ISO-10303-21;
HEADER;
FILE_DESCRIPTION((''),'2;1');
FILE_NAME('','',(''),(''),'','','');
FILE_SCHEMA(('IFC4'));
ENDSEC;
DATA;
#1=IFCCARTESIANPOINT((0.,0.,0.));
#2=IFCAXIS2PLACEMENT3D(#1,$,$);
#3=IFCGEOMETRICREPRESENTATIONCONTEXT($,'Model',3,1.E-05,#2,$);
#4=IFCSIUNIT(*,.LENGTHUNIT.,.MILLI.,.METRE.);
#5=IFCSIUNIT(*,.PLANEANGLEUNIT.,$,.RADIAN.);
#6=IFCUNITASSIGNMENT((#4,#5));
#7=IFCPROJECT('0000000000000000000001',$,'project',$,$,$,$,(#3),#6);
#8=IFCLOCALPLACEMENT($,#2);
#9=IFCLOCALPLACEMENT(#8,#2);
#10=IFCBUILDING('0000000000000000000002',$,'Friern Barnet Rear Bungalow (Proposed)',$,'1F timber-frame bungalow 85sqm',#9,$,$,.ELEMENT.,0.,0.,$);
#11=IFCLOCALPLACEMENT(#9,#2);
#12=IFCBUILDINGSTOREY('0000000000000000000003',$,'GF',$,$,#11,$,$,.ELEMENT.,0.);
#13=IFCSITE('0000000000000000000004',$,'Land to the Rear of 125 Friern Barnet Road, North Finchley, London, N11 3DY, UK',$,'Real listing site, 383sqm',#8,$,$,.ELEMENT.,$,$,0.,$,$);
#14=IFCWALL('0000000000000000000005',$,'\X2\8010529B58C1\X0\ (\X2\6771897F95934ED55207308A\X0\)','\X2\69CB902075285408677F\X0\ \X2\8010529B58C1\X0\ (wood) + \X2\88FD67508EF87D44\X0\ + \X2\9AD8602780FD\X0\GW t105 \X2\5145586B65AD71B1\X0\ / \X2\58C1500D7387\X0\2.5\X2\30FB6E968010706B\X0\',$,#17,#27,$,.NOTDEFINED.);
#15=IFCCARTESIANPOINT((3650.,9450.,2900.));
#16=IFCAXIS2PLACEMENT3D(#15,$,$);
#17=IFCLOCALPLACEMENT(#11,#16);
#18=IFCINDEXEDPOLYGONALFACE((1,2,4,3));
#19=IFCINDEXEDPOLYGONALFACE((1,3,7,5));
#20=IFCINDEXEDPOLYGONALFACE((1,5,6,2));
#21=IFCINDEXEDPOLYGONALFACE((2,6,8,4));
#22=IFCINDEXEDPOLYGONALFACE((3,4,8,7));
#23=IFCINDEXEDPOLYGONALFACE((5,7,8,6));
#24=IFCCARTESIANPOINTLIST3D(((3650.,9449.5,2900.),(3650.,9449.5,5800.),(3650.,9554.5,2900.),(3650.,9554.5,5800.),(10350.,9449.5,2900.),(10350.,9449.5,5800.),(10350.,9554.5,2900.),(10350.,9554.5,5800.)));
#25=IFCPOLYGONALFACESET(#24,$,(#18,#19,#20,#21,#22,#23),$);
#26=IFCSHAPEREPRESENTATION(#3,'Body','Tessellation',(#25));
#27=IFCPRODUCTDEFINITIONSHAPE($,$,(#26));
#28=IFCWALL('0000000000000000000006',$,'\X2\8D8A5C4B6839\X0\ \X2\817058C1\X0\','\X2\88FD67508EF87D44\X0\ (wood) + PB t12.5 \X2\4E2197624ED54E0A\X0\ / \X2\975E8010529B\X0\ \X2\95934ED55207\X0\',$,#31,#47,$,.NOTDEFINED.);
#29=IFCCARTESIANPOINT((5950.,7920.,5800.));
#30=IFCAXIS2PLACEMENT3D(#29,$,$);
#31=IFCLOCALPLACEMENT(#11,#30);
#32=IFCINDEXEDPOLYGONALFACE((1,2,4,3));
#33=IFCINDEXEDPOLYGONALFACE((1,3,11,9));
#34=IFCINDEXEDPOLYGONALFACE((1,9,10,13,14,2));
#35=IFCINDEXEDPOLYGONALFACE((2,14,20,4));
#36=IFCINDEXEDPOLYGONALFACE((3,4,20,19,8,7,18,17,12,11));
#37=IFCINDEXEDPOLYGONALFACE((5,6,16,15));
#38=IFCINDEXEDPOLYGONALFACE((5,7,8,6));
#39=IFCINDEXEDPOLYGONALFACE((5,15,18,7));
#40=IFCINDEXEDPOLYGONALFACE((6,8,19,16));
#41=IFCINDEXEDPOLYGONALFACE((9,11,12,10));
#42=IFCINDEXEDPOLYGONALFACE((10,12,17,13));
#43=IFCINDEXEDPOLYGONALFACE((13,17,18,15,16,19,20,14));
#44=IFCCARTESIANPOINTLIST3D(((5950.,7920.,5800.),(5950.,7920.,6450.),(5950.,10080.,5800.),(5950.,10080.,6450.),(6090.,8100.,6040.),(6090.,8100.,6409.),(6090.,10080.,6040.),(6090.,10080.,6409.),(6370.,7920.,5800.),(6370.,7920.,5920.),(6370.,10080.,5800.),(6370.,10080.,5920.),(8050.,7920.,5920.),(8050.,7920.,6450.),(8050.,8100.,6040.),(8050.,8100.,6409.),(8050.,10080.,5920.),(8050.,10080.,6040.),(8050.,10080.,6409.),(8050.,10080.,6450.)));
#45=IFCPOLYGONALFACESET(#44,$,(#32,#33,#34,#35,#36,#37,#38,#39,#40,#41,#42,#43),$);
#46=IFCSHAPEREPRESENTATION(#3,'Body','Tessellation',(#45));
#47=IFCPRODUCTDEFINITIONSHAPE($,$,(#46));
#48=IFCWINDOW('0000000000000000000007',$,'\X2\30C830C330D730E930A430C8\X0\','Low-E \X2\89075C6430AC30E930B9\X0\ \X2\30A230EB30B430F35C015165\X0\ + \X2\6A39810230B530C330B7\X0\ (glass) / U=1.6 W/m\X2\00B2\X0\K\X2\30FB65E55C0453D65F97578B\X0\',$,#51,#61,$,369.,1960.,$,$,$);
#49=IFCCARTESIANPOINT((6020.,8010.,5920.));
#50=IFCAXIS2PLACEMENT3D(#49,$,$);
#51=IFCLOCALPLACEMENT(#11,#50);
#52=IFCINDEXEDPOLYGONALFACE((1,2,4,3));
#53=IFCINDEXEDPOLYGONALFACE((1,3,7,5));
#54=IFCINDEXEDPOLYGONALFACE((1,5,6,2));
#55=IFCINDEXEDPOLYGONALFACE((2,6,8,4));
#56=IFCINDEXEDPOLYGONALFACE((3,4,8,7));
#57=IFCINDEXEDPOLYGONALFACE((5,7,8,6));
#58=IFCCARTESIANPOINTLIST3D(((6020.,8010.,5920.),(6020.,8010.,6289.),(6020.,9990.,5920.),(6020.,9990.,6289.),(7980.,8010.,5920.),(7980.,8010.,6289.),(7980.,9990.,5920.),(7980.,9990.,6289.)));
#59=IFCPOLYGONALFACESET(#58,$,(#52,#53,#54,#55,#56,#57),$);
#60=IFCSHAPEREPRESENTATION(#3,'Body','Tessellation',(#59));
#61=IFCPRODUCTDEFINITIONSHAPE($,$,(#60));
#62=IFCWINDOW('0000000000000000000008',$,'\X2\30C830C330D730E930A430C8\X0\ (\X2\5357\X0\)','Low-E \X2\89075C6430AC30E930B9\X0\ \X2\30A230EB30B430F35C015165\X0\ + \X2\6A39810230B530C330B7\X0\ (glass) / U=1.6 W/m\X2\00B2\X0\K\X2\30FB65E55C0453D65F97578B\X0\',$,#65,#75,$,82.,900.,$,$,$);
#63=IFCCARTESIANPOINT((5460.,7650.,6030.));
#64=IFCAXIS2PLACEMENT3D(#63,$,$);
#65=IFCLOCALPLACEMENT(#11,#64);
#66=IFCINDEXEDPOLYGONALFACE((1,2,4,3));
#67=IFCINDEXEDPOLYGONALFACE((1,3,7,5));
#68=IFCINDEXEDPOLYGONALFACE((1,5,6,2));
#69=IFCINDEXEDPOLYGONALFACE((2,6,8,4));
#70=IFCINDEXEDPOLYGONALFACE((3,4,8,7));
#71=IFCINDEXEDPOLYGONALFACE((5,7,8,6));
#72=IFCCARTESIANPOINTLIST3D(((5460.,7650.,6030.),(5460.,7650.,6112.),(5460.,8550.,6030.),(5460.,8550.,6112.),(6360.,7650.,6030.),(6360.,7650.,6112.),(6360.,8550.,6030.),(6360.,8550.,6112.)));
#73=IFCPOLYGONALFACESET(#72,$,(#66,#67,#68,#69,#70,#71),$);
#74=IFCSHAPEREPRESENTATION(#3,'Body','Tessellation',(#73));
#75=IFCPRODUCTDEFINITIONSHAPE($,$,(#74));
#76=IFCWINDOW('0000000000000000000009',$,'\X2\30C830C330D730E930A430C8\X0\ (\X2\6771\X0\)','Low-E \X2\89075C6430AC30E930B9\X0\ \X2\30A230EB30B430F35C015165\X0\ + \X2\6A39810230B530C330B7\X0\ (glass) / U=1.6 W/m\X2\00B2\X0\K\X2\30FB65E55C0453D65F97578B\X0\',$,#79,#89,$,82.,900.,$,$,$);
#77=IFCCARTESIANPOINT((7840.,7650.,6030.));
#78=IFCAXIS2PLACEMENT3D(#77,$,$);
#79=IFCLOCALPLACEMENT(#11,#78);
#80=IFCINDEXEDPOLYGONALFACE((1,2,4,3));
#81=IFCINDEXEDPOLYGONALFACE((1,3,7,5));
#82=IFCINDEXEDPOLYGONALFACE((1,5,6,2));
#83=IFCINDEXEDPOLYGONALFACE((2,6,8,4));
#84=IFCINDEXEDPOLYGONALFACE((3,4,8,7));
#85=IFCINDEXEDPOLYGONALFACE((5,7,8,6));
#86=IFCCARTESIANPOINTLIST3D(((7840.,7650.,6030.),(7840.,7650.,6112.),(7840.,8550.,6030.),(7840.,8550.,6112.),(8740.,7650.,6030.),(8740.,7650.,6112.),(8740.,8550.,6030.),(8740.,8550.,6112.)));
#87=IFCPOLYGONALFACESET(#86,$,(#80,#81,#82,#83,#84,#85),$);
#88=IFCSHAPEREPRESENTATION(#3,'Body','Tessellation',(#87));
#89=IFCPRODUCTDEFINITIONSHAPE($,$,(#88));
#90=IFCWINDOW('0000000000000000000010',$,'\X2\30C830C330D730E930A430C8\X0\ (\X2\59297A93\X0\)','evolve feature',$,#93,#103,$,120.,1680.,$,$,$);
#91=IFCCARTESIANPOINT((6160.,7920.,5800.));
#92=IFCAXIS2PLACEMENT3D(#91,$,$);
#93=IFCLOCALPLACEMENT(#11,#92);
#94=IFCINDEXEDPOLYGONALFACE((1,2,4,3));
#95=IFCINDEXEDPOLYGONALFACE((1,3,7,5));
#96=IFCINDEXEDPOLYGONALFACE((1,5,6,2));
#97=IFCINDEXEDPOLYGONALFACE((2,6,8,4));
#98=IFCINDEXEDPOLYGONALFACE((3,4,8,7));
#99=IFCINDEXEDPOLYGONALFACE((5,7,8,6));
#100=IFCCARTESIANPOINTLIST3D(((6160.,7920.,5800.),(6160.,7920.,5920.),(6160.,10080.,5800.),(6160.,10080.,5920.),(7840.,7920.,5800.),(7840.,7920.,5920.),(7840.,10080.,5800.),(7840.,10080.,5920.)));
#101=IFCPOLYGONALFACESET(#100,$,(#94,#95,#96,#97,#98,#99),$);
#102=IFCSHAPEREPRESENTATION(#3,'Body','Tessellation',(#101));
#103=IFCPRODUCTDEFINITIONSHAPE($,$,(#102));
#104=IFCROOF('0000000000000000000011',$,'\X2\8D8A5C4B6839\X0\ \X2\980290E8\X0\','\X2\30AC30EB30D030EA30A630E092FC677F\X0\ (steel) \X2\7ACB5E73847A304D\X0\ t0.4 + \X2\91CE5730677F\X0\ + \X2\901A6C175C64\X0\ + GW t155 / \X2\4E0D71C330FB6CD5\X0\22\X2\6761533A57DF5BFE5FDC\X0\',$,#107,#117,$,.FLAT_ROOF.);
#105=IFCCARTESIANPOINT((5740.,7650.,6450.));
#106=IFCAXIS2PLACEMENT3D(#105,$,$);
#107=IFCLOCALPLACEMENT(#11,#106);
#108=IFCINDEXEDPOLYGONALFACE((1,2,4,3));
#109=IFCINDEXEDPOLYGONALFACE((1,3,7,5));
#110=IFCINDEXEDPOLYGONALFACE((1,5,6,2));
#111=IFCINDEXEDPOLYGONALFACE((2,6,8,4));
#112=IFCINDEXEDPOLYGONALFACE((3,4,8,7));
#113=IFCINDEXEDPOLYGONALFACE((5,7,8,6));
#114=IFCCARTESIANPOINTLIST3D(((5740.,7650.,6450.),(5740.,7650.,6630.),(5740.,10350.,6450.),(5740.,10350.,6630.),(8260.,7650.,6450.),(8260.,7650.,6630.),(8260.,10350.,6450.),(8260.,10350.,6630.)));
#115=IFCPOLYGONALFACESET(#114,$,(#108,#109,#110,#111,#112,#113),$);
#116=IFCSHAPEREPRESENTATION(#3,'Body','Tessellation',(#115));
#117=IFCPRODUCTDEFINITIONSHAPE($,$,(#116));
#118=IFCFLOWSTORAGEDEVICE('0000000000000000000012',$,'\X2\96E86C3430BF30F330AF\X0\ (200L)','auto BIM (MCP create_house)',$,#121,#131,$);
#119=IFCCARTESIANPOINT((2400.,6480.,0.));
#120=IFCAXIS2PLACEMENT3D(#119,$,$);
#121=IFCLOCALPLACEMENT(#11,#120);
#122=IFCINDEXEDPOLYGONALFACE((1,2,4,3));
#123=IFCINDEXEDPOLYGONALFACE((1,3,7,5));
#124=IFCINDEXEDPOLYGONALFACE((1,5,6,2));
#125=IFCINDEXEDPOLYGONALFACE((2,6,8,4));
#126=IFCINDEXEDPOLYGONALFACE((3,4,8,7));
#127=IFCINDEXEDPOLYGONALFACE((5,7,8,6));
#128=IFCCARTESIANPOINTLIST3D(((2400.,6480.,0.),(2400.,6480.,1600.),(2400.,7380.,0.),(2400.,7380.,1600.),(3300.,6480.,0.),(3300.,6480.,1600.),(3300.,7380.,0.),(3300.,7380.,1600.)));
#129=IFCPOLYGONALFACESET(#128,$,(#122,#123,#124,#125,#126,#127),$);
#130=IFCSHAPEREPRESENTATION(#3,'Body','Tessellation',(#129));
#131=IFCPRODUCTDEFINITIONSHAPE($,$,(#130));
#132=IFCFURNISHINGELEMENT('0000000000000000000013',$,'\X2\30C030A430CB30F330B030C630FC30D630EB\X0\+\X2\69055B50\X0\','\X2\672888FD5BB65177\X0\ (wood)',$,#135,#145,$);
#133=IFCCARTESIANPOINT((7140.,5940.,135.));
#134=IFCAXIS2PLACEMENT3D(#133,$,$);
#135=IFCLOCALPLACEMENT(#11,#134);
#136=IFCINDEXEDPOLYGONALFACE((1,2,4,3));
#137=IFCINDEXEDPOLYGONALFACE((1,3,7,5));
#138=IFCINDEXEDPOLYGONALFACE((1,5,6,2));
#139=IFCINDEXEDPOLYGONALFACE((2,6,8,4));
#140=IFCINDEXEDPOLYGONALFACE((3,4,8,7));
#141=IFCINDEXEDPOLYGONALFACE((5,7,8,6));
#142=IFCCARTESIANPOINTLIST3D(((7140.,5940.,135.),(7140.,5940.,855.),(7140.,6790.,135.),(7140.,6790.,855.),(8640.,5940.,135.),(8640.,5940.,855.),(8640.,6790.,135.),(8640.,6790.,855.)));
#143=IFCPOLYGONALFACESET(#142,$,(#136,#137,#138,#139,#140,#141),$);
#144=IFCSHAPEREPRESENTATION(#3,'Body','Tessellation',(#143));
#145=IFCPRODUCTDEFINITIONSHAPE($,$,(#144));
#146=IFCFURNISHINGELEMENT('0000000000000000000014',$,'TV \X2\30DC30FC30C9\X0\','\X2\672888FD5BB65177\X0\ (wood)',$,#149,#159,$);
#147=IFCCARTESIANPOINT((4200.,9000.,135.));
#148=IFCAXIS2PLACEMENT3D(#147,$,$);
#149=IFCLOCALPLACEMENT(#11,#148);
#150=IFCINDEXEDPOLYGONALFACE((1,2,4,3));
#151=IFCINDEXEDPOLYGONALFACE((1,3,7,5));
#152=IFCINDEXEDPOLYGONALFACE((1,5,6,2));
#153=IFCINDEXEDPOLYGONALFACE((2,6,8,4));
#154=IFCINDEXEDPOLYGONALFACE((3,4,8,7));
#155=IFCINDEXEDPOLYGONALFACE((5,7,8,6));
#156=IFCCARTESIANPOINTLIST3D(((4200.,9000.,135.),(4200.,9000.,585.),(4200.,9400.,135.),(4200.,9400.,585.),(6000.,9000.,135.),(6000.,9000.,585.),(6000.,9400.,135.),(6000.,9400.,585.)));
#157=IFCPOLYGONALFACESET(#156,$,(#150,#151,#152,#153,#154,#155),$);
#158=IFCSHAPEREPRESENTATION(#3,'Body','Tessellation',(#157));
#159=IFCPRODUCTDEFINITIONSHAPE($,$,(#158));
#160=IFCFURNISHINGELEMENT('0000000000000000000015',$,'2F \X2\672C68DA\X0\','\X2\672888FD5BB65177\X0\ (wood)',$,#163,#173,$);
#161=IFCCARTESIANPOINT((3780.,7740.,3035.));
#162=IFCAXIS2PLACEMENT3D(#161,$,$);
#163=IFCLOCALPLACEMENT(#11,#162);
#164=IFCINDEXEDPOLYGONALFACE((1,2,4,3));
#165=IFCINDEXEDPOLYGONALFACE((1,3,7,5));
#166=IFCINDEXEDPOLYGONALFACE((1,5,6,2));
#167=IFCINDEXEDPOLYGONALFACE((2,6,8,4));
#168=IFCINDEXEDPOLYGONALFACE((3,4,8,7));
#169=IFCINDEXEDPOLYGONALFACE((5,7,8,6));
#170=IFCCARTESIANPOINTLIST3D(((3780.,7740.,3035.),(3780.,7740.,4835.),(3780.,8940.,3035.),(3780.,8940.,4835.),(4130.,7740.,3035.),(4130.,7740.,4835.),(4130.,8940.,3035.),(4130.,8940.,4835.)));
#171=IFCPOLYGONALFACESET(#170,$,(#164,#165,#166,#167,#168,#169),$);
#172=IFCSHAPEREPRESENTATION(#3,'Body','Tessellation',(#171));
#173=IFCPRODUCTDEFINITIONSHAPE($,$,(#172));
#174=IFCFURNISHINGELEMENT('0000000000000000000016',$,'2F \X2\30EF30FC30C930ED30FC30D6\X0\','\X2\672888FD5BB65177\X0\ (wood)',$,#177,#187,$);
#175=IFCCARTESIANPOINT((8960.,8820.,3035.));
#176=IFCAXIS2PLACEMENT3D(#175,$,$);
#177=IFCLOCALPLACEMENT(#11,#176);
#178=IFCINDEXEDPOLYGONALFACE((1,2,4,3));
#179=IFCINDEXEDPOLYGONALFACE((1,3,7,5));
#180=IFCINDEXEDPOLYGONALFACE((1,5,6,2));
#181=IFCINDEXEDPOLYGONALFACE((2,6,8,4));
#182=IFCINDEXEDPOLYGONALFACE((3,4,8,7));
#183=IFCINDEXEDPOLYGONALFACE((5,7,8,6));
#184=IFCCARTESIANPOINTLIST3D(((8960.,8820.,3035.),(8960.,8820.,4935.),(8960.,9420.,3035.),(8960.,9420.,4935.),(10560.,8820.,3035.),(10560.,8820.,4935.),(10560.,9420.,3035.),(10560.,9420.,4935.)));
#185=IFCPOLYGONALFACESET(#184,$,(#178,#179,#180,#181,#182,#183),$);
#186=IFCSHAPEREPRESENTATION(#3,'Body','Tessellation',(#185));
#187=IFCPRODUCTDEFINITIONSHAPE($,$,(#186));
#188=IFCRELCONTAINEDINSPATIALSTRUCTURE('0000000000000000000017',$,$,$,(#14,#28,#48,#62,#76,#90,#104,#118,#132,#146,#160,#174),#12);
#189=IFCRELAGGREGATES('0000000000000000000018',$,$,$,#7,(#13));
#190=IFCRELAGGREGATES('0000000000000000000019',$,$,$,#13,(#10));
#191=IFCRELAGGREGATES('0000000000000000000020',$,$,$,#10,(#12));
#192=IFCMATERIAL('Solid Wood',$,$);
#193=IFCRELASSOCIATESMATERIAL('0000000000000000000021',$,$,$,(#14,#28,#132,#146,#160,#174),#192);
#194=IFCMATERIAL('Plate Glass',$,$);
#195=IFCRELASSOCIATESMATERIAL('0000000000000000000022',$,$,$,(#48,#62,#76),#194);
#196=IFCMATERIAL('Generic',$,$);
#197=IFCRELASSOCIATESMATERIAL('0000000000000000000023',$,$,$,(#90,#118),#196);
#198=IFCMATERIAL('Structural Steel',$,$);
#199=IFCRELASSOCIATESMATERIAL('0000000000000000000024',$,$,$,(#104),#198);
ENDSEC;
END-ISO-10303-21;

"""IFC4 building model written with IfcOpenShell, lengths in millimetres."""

from ifc_helpers import new_model, si_unit, frame, frame_2d, origin, place, context, project, spatial, rectangle, extrude, material, element, fill, save


model = new_model("IFC4")

# Units and contexts
model_context = context("Model", 3, precision=1e-05, world=origin())
ifc_project = project(units=[si_unit("LENGTHUNIT", "METRE", prefix="MILLI"), si_unit("PLANEANGLEUNIT", "RADIAN")], contexts=[model_context])

# Site, building, storey
site_placement = place(None, origin())
site = spatial("IfcSite", under=ifc_project, at=site_placement, Name="Land to the Rear of 125 Friern Barnet Road, North Finchley, London, N11 3DY, UK", ObjectType="Real listing site, 383sqm", CompositionType="ELEMENT", RefElevation=0.0)
building_placement = place(site_placement, origin())
building = spatial("IfcBuilding", under=site, at=building_placement, Name="Friern Barnet Rear Bungalow (Proposed)", ObjectType="1F timber-frame bungalow 85sqm", CompositionType="ELEMENT", ElevationOfRefHeight=0.0, ElevationOfTerrain=0.0)
storey_placement = place(building_placement, origin())
storey = spatial("IfcBuildingStorey", under=building, at=storey_placement, Name="GF", CompositionType="ELEMENT", Elevation=0.0)

# Wall
ifc_material_1 = material(Name="Solid Wood")
wall_1_placement = place(storey_placement, frame((3650.0, 9450.0, 2900.0)))
element("IfcWall", 1, at=wall_1_placement, inside=storey, material=ifc_material_1, Name="耐力壁 (東西間仕切り)", Description="構造用合板 耐力壁 (wood) + 製材軸組 + 高性能GW t105 充填断熱 / 壁倍率2.5・準耐火", PredefinedType="NOTDEFINED", context=model_context, shape_type="SweptSolid", body=[
    extrude(rectangle(XDim=6700.0, YDim=105.0, at=frame_2d((3350.0, 52.0))), frame((3650.0, 9450.0, 2900.0)), (0.0, 0.0, 1.0), 2900.0),
])

# Wall, openings, windows
wall_2_placement = place(storey_placement, frame((5950.0, 7920.0, 5800.0)))
wall_2 = element("IfcWall", 2, at=wall_2_placement, inside=storey, material=ifc_material_1, Name="越屋根 腰壁", Description="製材軸組 (wood) + PB t12.5 両面仕上 / 非耐力 間仕切", PredefinedType="NOTDEFINED", context=model_context, shape_type="SweptSolid", body=[
    extrude(rectangle(XDim=2100.0, YDim=2160.0, at=frame_2d((1050.0, 1080.0))), frame((5950.0, 7920.0, 5800.0)), (0.0, 0.0, 1.0), 650.0),
])
opening_1_placement = place(storey_placement, frame((6020.0, 8010.0, 5920.0)))
opening_1 = element("IfcOpeningElement", 3, at=opening_1_placement, cuts=wall_2, PredefinedType="NOTDEFINED", context=model_context, shape_type="SweptSolid", body=[
    extrude(rectangle(XDim=1960.0, YDim=1980.0, at=frame_2d((980.0, 990.0))), frame((6020.0, 8010.0, 5920.0)), (0.0, 0.0, 1.0), 369.0),
])
opening_2_placement = place(storey_placement, frame((5460.0, 7650.0, 6030.0)))
opening_2 = element("IfcOpeningElement", 4, at=opening_2_placement, cuts=wall_2, PredefinedType="NOTDEFINED", context=model_context, shape_type="SweptSolid", body=[
    extrude(rectangle(XDim=900.0, YDim=900.0, at=frame_2d((450.0, 450.0))), frame((5460.0, 7650.0, 6030.0)), (0.0, 0.0, 1.0), 82.0),
])
opening_3_placement = place(storey_placement, frame((7840.0, 7650.0, 6030.0)))
opening_3 = element("IfcOpeningElement", 5, at=opening_3_placement, cuts=wall_2, PredefinedType="NOTDEFINED", context=model_context, shape_type="SweptSolid", body=[
    extrude(rectangle(XDim=900.0, YDim=900.0, at=frame_2d((450.0, 450.0))), frame((7840.0, 7650.0, 6030.0)), (0.0, 0.0, 1.0), 82.0),
])
opening_4_placement = place(storey_placement, frame((6160.0, 7920.0, 5800.0)))
opening_4 = element("IfcOpeningElement", 6, at=opening_4_placement, cuts=wall_2, PredefinedType="NOTDEFINED", context=model_context, shape_type="SweptSolid", body=[
    extrude(rectangle(XDim=1680.0, YDim=2160.0, at=frame_2d((840.0, 1080.0))), frame((6160.0, 7920.0, 5800.0)), (0.0, 0.0, 1.0), 120.0),
])
ifc_material_2 = material(Name="Plate Glass")
window_1_placement = place(storey_placement, frame((6020.0, 8010.0, 5920.0)))
window_1 = element("IfcWindow", 7, at=window_1_placement, inside=storey, material=ifc_material_2, Name="トップライト", Description="Low-E 複層ガラス アルゴン封入 + 樹脂サッシ (glass) / U=1.6 W/m²K・日射取得型", OverallHeight=369.0, OverallWidth=1960.0, context=model_context, shape_type="SweptSolid", body=[
    extrude(rectangle(XDim=1960.0, YDim=1980.0, at=frame_2d((980.0, 990.0))), frame((6020.0, 8010.0, 5920.0)), (0.0, 0.0, 1.0), 369.0),
])
fill(opening_1, window_1)
window_2_placement = place(storey_placement, frame((5460.0, 7650.0, 6030.0)))
window_2 = element("IfcWindow", 8, at=window_2_placement, inside=storey, material=ifc_material_2, Name="トップライト (南)", Description="Low-E 複層ガラス アルゴン封入 + 樹脂サッシ (glass) / U=1.6 W/m²K・日射取得型", OverallHeight=82.0, OverallWidth=900.0, context=model_context, shape_type="SweptSolid", body=[
    extrude(rectangle(XDim=900.0, YDim=900.0, at=frame_2d((450.0, 450.0))), frame((5460.0, 7650.0, 6030.0)), (0.0, 0.0, 1.0), 82.0),
])
fill(opening_2, window_2)
window_3_placement = place(storey_placement, frame((7840.0, 7650.0, 6030.0)))
window_3 = element("IfcWindow", 9, at=window_3_placement, inside=storey, material=ifc_material_2, Name="トップライト (東)", Description="Low-E 複層ガラス アルゴン封入 + 樹脂サッシ (glass) / U=1.6 W/m²K・日射取得型", OverallHeight=82.0, OverallWidth=900.0, context=model_context, shape_type="SweptSolid", body=[
    extrude(rectangle(XDim=900.0, YDim=900.0, at=frame_2d((450.0, 450.0))), frame((7840.0, 7650.0, 6030.0)), (0.0, 0.0, 1.0), 82.0),
])
fill(opening_3, window_3)
ifc_material_3 = material(Name="Generic")
window_4_placement = place(storey_placement, frame((6160.0, 7920.0, 5800.0)))
window_4 = element("IfcWindow", 10, at=window_4_placement, inside=storey, material=ifc_material_3, Name="トップライト (天窓)", Description="evolve feature", OverallHeight=120.0, OverallWidth=1680.0, context=model_context, shape_type="SweptSolid", body=[
    extrude(rectangle(XDim=1680.0, YDim=2160.0, at=frame_2d((840.0, 1080.0))), frame((6160.0, 7920.0, 5800.0)), (0.0, 0.0, 1.0), 120.0),
])
fill(opening_4, window_4)

# Roof
ifc_material_4 = material(Name="Structural Steel")
roof_placement = place(storey_placement, frame((5740.0, 7650.0, 6450.0)))
element("IfcRoof", 11, at=roof_placement, inside=storey, material=ifc_material_4, Name="越屋根 頂部", Description="ガルバリウム鋼板 (steel) 立平葺き t0.4 + 野地板 + 通気層 + GW t155 / 不燃・法22条区域対応", PredefinedType="FLAT_ROOF", context=model_context, shape_type="SweptSolid", body=[
    extrude(rectangle(XDim=2520.0, YDim=2700.0, at=frame_2d((1260.0, 1350.0))), frame((5740.0, 7650.0, 6450.0)), (0.0, 0.0, 1.0), 180.0),
])

# Flow storage device
flow_storage_device_placement = place(storey_placement, frame((2400.0, 6480.0, 0.0)))
element("IfcFlowStorageDevice", 12, at=flow_storage_device_placement, inside=storey, material=ifc_material_3, Name="雨水タンク (200L)", Description="auto BIM (MCP create_house)", context=model_context, shape_type="SweptSolid", body=[
    extrude(rectangle(XDim=900.0, YDim=900.0, at=frame_2d((450.0, 450.0))), frame((2400.0, 6480.0, 0.0)), (0.0, 0.0, 1.0), 1600.0),
])

# Furnishing elements
furnishing_1_placement = place(storey_placement, frame((7140.0, 5940.0, 135.0)))
element("IfcFurnishingElement", 13, at=furnishing_1_placement, inside=storey, material=ifc_material_1, Name="ダイニングテーブル+椅子", Description="木製家具 (wood)", context=model_context, shape_type="SweptSolid", body=[
    extrude(rectangle(XDim=1500.0, YDim=850.0, at=frame_2d((750.0, 425.0))), frame((7140.0, 5940.0, 135.0)), (0.0, 0.0, 1.0), 720.0),
])
furnishing_2_placement = place(storey_placement, frame((4200.0, 9000.0, 135.0)))
element("IfcFurnishingElement", 14, at=furnishing_2_placement, inside=storey, material=ifc_material_1, Name="TV ボード", Description="木製家具 (wood)", context=model_context, shape_type="SweptSolid", body=[
    extrude(rectangle(XDim=1800.0, YDim=400.0, at=frame_2d((900.0, 200.0))), frame((4200.0, 9000.0, 135.0)), (0.0, 0.0, 1.0), 450.0),
])
furnishing_3_placement = place(storey_placement, frame((3780.0, 7740.0, 3035.0)))
element("IfcFurnishingElement", 15, at=furnishing_3_placement, inside=storey, material=ifc_material_1, Name="2F 本棚", Description="木製家具 (wood)", context=model_context, shape_type="SweptSolid", body=[
    extrude(rectangle(XDim=350.0, YDim=1200.0, at=frame_2d((175.0, 600.0))), frame((3780.0, 7740.0, 3035.0)), (0.0, 0.0, 1.0), 1800.0),
])
furnishing_4_placement = place(storey_placement, frame((8960.0, 8820.0, 3035.0)))
element("IfcFurnishingElement", 16, at=furnishing_4_placement, inside=storey, material=ifc_material_1, Name="2F ワードローブ", Description="木製家具 (wood)", context=model_context, shape_type="SweptSolid", body=[
    extrude(rectangle(XDim=1600.0, YDim=600.0, at=frame_2d((800.0, 300.0))), frame((8960.0, 8820.0, 3035.0)), (0.0, 0.0, 1.0), 1900.0),
])

save(model, "model.ifc")
